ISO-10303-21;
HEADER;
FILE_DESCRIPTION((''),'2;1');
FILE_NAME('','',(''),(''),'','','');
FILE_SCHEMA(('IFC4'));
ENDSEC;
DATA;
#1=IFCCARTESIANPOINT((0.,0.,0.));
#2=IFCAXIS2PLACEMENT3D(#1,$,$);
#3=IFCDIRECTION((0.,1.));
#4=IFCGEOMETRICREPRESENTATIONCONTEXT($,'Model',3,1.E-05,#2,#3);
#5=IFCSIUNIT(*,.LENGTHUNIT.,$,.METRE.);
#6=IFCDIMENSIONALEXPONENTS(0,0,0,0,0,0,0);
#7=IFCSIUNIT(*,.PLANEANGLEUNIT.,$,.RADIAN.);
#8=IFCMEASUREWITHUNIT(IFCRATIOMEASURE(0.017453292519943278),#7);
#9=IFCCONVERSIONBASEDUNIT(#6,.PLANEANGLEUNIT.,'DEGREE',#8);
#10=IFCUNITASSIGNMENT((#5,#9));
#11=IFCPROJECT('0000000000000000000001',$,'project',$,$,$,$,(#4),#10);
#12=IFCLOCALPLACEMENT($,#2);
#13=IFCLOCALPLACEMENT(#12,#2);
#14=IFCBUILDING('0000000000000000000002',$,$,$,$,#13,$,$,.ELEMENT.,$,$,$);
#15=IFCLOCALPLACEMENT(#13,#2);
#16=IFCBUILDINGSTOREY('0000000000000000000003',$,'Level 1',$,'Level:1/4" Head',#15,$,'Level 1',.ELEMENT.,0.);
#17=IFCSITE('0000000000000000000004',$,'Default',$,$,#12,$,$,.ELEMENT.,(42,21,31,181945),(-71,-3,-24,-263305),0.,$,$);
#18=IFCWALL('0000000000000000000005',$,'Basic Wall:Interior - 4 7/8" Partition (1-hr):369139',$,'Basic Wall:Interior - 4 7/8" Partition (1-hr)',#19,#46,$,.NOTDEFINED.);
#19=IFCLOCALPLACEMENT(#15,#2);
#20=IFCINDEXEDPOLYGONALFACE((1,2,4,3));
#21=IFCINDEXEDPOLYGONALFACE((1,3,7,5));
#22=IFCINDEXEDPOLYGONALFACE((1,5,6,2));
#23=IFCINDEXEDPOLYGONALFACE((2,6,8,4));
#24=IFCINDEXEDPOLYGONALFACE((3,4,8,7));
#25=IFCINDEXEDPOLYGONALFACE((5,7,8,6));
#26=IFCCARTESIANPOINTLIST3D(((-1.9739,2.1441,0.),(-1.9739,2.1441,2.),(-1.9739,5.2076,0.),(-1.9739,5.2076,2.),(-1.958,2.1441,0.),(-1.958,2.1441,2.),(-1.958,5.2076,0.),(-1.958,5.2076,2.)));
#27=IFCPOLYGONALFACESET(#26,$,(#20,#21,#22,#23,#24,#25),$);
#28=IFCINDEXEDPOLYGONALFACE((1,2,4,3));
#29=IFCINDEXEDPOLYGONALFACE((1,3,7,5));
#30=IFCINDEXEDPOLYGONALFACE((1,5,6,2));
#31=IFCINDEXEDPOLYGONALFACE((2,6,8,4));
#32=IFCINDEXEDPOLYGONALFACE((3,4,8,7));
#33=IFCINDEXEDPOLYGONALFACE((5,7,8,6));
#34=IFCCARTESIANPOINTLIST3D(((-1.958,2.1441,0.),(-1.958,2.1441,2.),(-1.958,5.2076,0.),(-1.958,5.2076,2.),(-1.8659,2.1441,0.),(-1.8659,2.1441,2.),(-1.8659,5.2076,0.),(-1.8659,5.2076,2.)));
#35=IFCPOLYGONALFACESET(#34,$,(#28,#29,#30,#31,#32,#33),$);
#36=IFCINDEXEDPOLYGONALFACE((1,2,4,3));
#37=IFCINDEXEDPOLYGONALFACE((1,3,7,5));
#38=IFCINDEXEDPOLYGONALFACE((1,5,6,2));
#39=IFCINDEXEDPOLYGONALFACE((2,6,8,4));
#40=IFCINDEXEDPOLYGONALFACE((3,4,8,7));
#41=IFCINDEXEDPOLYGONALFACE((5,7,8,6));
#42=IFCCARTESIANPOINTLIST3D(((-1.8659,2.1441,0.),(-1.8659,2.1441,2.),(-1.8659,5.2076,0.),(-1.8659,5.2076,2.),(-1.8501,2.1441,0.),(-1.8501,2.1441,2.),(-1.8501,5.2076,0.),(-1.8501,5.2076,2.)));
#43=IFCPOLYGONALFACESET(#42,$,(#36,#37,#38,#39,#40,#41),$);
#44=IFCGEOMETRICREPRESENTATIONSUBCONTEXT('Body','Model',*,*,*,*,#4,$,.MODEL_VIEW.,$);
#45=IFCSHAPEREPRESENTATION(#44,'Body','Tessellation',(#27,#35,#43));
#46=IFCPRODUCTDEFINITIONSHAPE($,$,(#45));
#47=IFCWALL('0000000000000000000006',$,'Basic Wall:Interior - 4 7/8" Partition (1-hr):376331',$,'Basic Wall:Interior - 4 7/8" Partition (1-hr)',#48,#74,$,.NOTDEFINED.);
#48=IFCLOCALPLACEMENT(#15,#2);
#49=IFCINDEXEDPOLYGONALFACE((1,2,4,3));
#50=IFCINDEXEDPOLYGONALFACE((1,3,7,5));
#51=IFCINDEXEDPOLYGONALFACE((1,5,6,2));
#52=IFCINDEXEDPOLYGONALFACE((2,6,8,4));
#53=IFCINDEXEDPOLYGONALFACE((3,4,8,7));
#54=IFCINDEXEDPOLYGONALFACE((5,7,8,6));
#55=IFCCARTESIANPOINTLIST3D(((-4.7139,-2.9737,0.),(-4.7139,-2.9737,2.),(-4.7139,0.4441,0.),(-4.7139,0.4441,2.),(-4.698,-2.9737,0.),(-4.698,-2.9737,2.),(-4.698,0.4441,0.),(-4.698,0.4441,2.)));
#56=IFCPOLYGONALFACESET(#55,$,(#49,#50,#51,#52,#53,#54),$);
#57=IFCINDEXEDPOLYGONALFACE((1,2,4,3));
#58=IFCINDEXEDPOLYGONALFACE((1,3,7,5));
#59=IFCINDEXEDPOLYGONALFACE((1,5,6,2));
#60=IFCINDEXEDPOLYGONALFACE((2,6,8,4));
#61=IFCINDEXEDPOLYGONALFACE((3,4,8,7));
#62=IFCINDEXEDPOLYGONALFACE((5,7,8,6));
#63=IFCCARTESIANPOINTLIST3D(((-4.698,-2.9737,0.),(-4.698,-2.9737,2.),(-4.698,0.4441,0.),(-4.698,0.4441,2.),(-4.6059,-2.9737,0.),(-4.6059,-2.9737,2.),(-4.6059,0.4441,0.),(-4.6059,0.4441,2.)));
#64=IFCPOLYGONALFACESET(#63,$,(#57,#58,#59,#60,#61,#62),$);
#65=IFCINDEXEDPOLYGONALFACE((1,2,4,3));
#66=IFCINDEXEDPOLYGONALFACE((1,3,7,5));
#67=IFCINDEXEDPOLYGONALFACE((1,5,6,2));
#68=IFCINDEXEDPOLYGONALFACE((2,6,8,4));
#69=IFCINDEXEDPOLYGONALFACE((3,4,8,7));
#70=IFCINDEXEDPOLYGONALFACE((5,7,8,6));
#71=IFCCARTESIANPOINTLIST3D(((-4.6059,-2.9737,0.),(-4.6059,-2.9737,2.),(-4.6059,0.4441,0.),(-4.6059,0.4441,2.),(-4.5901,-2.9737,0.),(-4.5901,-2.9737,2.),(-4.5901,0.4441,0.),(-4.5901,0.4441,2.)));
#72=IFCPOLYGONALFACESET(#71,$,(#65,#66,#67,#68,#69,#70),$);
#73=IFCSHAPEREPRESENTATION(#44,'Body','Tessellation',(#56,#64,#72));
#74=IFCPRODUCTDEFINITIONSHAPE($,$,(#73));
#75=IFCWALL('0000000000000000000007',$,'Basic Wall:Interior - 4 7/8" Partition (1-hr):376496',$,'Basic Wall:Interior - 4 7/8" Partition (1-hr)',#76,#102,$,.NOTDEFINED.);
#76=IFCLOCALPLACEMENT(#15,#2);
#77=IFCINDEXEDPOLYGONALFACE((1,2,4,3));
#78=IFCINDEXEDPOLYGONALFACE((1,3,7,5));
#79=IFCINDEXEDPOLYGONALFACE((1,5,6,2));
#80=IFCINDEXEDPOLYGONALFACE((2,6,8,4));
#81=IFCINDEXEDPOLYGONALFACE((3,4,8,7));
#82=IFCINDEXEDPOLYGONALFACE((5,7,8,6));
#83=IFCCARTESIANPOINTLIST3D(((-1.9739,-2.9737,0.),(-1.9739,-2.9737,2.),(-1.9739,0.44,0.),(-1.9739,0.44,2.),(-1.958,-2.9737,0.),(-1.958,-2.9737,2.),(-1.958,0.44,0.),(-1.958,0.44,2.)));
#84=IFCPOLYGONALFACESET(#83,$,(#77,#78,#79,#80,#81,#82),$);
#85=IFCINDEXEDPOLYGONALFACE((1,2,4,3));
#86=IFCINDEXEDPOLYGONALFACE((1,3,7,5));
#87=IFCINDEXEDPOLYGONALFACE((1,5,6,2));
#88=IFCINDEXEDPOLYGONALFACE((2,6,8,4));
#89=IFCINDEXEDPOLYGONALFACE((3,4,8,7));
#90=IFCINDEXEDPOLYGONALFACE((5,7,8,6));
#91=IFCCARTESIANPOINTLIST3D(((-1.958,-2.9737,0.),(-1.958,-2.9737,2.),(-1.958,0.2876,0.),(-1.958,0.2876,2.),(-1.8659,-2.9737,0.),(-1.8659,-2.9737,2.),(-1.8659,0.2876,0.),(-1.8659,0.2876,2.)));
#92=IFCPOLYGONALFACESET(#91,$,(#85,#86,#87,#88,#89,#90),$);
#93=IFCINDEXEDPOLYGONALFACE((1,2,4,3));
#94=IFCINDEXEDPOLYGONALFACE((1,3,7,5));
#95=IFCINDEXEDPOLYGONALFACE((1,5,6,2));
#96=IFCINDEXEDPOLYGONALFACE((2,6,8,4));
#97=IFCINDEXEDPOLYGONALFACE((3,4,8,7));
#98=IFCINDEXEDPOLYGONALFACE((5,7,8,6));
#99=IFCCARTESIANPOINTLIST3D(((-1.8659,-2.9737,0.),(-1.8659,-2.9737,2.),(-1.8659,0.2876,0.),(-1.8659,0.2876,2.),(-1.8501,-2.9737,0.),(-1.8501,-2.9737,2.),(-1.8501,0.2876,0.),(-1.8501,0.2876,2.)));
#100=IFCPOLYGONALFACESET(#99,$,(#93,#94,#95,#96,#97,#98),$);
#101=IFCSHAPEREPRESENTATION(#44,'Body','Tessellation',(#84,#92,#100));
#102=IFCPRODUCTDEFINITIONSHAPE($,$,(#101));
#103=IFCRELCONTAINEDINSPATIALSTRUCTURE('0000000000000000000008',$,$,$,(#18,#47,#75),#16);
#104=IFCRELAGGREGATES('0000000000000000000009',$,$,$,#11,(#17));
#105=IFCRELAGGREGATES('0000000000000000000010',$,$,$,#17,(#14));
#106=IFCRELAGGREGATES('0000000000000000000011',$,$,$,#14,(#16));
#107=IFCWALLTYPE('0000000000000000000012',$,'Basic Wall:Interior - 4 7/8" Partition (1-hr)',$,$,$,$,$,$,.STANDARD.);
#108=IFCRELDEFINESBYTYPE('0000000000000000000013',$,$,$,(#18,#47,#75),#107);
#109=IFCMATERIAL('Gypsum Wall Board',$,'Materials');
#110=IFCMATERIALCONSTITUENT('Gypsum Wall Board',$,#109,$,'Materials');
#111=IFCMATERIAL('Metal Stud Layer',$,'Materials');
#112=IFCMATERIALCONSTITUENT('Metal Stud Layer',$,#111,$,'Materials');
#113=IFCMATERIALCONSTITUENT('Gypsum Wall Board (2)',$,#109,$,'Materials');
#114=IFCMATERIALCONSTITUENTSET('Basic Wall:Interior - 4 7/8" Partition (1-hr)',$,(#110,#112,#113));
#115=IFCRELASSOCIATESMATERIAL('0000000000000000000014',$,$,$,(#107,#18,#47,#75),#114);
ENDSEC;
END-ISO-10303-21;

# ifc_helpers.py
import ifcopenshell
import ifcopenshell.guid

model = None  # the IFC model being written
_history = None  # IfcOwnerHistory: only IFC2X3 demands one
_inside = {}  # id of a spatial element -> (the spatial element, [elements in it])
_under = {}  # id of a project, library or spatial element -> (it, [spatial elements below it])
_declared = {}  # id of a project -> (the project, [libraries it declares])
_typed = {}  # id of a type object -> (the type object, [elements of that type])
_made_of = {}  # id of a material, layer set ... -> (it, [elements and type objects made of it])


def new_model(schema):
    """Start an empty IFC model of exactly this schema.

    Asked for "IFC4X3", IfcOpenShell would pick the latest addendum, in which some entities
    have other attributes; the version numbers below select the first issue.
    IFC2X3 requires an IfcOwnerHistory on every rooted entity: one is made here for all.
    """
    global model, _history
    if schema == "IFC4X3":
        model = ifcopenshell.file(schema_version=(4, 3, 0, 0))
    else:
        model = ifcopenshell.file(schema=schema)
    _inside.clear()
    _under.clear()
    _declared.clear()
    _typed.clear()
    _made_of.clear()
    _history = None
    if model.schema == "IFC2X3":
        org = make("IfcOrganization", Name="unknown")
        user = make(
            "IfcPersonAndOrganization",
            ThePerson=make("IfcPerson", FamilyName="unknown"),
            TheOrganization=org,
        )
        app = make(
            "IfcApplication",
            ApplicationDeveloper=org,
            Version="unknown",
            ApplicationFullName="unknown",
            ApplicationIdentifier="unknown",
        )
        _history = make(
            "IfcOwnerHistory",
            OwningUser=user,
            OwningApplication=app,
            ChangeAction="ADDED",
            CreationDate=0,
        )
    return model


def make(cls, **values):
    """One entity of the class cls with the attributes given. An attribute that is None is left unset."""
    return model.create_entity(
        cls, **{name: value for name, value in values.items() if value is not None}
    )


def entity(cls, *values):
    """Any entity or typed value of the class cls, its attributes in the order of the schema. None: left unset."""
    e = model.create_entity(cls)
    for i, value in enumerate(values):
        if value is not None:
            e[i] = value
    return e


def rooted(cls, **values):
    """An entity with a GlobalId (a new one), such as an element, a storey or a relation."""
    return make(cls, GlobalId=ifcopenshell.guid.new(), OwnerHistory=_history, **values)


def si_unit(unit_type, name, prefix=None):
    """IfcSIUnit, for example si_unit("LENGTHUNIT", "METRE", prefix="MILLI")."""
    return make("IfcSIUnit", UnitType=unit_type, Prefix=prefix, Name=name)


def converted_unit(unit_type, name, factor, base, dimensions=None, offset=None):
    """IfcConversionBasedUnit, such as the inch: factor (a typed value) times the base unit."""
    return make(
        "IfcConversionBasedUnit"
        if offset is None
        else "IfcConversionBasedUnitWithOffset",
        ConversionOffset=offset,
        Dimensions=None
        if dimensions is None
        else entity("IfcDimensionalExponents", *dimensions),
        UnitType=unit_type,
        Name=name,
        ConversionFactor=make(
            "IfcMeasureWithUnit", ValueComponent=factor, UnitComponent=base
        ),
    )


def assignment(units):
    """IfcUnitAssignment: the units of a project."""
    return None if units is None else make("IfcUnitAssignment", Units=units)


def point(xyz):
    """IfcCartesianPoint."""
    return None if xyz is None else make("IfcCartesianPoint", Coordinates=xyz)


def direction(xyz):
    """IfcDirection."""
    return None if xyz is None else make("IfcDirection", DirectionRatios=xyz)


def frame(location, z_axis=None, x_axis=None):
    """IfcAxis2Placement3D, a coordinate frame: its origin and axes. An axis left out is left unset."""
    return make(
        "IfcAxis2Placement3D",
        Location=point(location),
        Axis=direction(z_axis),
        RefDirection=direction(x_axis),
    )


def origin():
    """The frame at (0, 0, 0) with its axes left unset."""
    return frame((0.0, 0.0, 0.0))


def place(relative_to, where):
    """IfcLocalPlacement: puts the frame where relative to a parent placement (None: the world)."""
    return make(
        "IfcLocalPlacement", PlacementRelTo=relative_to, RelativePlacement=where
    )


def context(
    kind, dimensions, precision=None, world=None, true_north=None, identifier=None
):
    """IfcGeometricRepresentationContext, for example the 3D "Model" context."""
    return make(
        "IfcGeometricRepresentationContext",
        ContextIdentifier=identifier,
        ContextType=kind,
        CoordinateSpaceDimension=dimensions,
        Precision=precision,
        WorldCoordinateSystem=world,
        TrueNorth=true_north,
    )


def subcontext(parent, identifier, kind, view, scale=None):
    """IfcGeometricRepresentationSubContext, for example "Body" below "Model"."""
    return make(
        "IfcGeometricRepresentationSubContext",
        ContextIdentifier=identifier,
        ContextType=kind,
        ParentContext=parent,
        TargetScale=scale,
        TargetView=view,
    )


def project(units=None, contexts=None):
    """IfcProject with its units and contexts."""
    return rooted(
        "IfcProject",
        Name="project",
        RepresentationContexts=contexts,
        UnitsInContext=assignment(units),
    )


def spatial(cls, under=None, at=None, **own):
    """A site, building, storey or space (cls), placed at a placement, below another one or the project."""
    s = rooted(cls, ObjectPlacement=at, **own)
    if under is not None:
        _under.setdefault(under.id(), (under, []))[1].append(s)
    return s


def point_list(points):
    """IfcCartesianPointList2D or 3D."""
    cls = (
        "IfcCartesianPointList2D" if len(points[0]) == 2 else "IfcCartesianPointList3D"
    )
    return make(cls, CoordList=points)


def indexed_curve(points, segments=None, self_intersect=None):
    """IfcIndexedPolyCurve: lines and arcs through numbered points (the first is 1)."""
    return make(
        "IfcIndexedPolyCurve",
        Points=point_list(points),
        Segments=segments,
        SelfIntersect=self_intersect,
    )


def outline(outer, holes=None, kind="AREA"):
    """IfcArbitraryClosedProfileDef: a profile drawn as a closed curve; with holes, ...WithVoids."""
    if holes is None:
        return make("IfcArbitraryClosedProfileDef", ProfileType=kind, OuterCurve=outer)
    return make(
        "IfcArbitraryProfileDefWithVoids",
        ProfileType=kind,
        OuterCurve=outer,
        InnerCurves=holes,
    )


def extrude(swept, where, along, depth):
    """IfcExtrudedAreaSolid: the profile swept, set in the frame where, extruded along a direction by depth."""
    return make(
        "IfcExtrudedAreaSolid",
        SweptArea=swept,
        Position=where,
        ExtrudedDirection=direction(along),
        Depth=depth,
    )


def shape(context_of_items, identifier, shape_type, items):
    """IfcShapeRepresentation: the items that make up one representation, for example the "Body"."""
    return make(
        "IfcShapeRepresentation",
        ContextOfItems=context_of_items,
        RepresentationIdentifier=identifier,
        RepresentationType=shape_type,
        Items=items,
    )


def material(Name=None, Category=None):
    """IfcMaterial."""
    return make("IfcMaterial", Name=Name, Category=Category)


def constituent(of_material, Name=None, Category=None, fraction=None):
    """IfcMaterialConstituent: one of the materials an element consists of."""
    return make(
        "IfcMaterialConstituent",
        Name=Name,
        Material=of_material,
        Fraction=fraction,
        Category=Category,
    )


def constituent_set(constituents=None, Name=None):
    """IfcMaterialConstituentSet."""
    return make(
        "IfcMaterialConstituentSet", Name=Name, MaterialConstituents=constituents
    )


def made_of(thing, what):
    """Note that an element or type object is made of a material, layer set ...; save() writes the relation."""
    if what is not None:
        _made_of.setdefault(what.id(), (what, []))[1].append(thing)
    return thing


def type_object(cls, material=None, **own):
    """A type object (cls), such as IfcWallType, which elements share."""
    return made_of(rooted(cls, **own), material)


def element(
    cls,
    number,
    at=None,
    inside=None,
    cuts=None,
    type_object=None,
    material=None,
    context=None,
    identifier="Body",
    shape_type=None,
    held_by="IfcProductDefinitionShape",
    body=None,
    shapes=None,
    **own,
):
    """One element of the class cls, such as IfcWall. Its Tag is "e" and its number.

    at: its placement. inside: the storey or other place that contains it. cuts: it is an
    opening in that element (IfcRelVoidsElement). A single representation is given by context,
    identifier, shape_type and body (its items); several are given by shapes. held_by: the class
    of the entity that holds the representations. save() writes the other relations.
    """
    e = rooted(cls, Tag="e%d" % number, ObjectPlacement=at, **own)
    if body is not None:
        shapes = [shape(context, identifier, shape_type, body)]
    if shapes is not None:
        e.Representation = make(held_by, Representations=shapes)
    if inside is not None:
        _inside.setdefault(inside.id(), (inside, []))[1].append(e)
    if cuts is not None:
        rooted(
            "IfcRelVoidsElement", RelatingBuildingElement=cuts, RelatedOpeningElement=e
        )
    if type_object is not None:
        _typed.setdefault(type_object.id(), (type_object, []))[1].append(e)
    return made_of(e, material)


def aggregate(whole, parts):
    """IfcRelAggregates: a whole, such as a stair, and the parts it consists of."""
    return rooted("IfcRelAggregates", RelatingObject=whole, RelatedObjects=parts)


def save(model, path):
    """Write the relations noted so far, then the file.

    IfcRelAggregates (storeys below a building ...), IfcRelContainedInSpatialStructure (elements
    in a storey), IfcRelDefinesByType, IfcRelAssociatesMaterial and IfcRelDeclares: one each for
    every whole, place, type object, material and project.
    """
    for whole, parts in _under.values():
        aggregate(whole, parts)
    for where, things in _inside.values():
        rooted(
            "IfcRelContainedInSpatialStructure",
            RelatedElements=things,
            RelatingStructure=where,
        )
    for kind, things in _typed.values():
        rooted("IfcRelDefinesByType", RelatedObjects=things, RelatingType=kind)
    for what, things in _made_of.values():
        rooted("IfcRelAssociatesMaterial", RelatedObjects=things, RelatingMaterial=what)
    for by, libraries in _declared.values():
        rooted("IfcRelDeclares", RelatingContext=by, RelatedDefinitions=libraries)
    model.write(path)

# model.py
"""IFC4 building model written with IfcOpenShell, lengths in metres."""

from ifc_helpers import new_model, entity, si_unit, converted_unit, direction, frame, origin, place, context, subcontext, project, spatial, indexed_curve, outline, extrude, material, constituent, constituent_set, type_object, element, save


model = new_model("IFC4")

# Units and contexts
model_context = context("Model", 3, precision=1e-05, world=origin(), true_north=direction((0.0, 1.0)))
body_context = subcontext(model_context, "Body", "Model", "MODEL_VIEW")
ifc_project = project(units=[si_unit("LENGTHUNIT", "METRE"), converted_unit("PLANEANGLEUNIT", "DEGREE", entity("IfcRatioMeasure", 0.017453292519943278), si_unit("PLANEANGLEUNIT", "RADIAN"), dimensions=[0, 0, 0, 0, 0, 0, 0])], contexts=[model_context])

# Site, building, storey
site_placement = place(None, origin())
site = spatial("IfcSite", under=ifc_project, at=site_placement, Name="Default", CompositionType="ELEMENT", RefLatitude=(42, 21, 31, 181945), RefLongitude=(-71, -3, -24, -263305), RefElevation=0.0)
building_placement = place(site_placement, origin())
building = spatial("IfcBuilding", under=site, at=building_placement, CompositionType="ELEMENT")
storey_placement = place(building_placement, origin())
storey = spatial("IfcBuildingStorey", under=building, at=storey_placement, Name="Level 1", ObjectType="Level:1/4\" Head", LongName="Level 1", CompositionType="ELEMENT", Elevation=0.0)

# Walls
ifc_material_1 = material(Name="Gypsum Wall Board", Category="Materials")
ifc_constituent_1 = constituent(ifc_material_1, Name="Gypsum Wall Board", Category="Materials")
ifc_material_2 = material(Name="Metal Stud Layer", Category="Materials")
ifc_constituent_2 = constituent(ifc_material_2, Name="Metal Stud Layer", Category="Materials")
ifc_constituent_3 = constituent(ifc_material_1, Name="Gypsum Wall Board (2)", Category="Materials")
ifc_constituent_set = constituent_set(constituents=[ifc_constituent_1, ifc_constituent_2, ifc_constituent_3], Name="Basic Wall:Interior - 4 7/8\" Partition (1-hr)")
wall_type_1 = type_object("IfcWallType", Name="Basic Wall:Interior - 4 7/8\" Partition (1-hr)", PredefinedType="STANDARD", material=ifc_constituent_set)
wall_1_placement = place(storey_placement, frame((-1.912, 5.2076, 0.0), z_axis=(0.0, 0.0, 1.0), x_axis=(0.0, -1.0, 0.0)))
element("IfcWall", 1, at=wall_1_placement, inside=storey, type_object=wall_type_1, material=ifc_constituent_set, Name="Basic Wall:Interior - 4 7/8\" Partition (1-hr):369139", ObjectType="Basic Wall:Interior - 4 7/8\" Partition (1-hr)", PredefinedType="NOTDEFINED", context=body_context, shape_type="SweptSolid", body=[
    extrude(outline(indexed_curve([(-0.0079, -1.5318), (0.0079, -1.5318), (0.0079, 1.5318), (-0.0079, 1.5318), (-0.0079, -1.5318)], self_intersect=False)), frame((1.5318, -0.054, 0.0), z_axis=(0.0, 0.0, 1.0), x_axis=(0.0, 1.0, 0.0)), (0.0, 0.0, 1.0), 2.0),
    extrude(outline(indexed_curve([(-1.5318, -0.046), (1.5318, -0.046), (1.5318, 0.046), (-1.5318, 0.046), (-1.5318, -0.046)], self_intersect=False)), frame((1.5318, 0.0, 0.0)), (0.0, 0.0, 1.0), 2.0),
    extrude(outline(indexed_curve([(-0.0079, -1.5318), (0.0079, -1.5318), (0.0079, 1.5318), (-0.0079, 1.5318), (-0.0079, -1.5318)], self_intersect=False)), frame((1.5318, 0.054, 0.0), z_axis=(0.0, 0.0, 1.0), x_axis=(0.0, -1.0, 0.0)), (0.0, 0.0, 1.0), 2.0),
])
wall_2_placement = place(storey_placement, frame((-4.652, 0.4441, 0.0), z_axis=(0.0, 0.0, 1.0), x_axis=(0.0, -1.0, 0.0)))
element("IfcWall", 2, at=wall_2_placement, inside=storey, type_object=wall_type_1, material=ifc_constituent_set, Name="Basic Wall:Interior - 4 7/8\" Partition (1-hr):376331", ObjectType="Basic Wall:Interior - 4 7/8\" Partition (1-hr)", PredefinedType="NOTDEFINED", context=body_context, shape_type="SweptSolid", body=[
    extrude(outline(indexed_curve([(-0.0079, -1.7089), (0.0079, -1.7089), (0.0079, 1.7089), (-0.0079, 1.7089), (-0.0079, -1.7089)], self_intersect=False)), frame((1.7089, -0.054, 0.0), z_axis=(0.0, 0.0, 1.0), x_axis=(0.0, 1.0, 0.0)), (0.0, 0.0, 1.0), 2.0),
    extrude(outline(indexed_curve([(-1.7089, -0.046), (1.7089, -0.046), (1.7089, 0.046), (-1.7089, 0.046), (-1.7089, -0.046)], self_intersect=False)), frame((1.7089, 0.0, 0.0)), (0.0, 0.0, 1.0), 2.0),
    extrude(outline(indexed_curve([(-0.0079, -1.7089), (0.0079, -1.7089), (0.0079, 1.7089), (-0.0079, 1.7089), (-0.0079, -1.7089)], self_intersect=False)), frame((1.7089, 0.054, 0.0), z_axis=(0.0, 0.0, 1.0), x_axis=(0.0, -1.0, 0.0)), (0.0, 0.0, 1.0), 2.0),
])
wall_3_placement = place(storey_placement, frame((-1.912, 0.2876, 0.0), z_axis=(0.0, 0.0, 1.0), x_axis=(0.0, -1.0, 0.0)))
element("IfcWall", 3, at=wall_3_placement, inside=storey, type_object=wall_type_1, material=ifc_constituent_set, Name="Basic Wall:Interior - 4 7/8\" Partition (1-hr):376496", ObjectType="Basic Wall:Interior - 4 7/8\" Partition (1-hr)", PredefinedType="NOTDEFINED", context=body_context, shape_type="SweptSolid", body=[
    extrude(outline(indexed_curve([(-0.0079, -1.7069), (0.0079, -1.7069), (0.0079, 1.7069), (-0.0079, 1.7069), (-0.0079, -1.7069)], self_intersect=False)), frame((1.5545, -0.054, 0.0), z_axis=(0.0, 0.0, 1.0), x_axis=(0.0, 1.0, 0.0)), (0.0, 0.0, 1.0), 2.0),
    extrude(outline(indexed_curve([(-1.6307, -0.046), (1.6307, -0.046), (1.6307, 0.046), (-1.6307, 0.046), (-1.6307, -0.046)], self_intersect=False)), frame((1.6307, 0.0, 0.0)), (0.0, 0.0, 1.0), 2.0),
    extrude(outline(indexed_curve([(-0.0079, -1.6307), (0.0079, -1.6307), (0.0079, 1.6307), (-0.0079, 1.6307), (-0.0079, -1.6307)], self_intersect=False)), frame((1.6307, 0.054, 0.0), z_axis=(0.0, 0.0, 1.0), x_axis=(0.0, -1.0, 0.0)), (0.0, 0.0, 1.0), 2.0),
])

save(model, "model.ifc")
